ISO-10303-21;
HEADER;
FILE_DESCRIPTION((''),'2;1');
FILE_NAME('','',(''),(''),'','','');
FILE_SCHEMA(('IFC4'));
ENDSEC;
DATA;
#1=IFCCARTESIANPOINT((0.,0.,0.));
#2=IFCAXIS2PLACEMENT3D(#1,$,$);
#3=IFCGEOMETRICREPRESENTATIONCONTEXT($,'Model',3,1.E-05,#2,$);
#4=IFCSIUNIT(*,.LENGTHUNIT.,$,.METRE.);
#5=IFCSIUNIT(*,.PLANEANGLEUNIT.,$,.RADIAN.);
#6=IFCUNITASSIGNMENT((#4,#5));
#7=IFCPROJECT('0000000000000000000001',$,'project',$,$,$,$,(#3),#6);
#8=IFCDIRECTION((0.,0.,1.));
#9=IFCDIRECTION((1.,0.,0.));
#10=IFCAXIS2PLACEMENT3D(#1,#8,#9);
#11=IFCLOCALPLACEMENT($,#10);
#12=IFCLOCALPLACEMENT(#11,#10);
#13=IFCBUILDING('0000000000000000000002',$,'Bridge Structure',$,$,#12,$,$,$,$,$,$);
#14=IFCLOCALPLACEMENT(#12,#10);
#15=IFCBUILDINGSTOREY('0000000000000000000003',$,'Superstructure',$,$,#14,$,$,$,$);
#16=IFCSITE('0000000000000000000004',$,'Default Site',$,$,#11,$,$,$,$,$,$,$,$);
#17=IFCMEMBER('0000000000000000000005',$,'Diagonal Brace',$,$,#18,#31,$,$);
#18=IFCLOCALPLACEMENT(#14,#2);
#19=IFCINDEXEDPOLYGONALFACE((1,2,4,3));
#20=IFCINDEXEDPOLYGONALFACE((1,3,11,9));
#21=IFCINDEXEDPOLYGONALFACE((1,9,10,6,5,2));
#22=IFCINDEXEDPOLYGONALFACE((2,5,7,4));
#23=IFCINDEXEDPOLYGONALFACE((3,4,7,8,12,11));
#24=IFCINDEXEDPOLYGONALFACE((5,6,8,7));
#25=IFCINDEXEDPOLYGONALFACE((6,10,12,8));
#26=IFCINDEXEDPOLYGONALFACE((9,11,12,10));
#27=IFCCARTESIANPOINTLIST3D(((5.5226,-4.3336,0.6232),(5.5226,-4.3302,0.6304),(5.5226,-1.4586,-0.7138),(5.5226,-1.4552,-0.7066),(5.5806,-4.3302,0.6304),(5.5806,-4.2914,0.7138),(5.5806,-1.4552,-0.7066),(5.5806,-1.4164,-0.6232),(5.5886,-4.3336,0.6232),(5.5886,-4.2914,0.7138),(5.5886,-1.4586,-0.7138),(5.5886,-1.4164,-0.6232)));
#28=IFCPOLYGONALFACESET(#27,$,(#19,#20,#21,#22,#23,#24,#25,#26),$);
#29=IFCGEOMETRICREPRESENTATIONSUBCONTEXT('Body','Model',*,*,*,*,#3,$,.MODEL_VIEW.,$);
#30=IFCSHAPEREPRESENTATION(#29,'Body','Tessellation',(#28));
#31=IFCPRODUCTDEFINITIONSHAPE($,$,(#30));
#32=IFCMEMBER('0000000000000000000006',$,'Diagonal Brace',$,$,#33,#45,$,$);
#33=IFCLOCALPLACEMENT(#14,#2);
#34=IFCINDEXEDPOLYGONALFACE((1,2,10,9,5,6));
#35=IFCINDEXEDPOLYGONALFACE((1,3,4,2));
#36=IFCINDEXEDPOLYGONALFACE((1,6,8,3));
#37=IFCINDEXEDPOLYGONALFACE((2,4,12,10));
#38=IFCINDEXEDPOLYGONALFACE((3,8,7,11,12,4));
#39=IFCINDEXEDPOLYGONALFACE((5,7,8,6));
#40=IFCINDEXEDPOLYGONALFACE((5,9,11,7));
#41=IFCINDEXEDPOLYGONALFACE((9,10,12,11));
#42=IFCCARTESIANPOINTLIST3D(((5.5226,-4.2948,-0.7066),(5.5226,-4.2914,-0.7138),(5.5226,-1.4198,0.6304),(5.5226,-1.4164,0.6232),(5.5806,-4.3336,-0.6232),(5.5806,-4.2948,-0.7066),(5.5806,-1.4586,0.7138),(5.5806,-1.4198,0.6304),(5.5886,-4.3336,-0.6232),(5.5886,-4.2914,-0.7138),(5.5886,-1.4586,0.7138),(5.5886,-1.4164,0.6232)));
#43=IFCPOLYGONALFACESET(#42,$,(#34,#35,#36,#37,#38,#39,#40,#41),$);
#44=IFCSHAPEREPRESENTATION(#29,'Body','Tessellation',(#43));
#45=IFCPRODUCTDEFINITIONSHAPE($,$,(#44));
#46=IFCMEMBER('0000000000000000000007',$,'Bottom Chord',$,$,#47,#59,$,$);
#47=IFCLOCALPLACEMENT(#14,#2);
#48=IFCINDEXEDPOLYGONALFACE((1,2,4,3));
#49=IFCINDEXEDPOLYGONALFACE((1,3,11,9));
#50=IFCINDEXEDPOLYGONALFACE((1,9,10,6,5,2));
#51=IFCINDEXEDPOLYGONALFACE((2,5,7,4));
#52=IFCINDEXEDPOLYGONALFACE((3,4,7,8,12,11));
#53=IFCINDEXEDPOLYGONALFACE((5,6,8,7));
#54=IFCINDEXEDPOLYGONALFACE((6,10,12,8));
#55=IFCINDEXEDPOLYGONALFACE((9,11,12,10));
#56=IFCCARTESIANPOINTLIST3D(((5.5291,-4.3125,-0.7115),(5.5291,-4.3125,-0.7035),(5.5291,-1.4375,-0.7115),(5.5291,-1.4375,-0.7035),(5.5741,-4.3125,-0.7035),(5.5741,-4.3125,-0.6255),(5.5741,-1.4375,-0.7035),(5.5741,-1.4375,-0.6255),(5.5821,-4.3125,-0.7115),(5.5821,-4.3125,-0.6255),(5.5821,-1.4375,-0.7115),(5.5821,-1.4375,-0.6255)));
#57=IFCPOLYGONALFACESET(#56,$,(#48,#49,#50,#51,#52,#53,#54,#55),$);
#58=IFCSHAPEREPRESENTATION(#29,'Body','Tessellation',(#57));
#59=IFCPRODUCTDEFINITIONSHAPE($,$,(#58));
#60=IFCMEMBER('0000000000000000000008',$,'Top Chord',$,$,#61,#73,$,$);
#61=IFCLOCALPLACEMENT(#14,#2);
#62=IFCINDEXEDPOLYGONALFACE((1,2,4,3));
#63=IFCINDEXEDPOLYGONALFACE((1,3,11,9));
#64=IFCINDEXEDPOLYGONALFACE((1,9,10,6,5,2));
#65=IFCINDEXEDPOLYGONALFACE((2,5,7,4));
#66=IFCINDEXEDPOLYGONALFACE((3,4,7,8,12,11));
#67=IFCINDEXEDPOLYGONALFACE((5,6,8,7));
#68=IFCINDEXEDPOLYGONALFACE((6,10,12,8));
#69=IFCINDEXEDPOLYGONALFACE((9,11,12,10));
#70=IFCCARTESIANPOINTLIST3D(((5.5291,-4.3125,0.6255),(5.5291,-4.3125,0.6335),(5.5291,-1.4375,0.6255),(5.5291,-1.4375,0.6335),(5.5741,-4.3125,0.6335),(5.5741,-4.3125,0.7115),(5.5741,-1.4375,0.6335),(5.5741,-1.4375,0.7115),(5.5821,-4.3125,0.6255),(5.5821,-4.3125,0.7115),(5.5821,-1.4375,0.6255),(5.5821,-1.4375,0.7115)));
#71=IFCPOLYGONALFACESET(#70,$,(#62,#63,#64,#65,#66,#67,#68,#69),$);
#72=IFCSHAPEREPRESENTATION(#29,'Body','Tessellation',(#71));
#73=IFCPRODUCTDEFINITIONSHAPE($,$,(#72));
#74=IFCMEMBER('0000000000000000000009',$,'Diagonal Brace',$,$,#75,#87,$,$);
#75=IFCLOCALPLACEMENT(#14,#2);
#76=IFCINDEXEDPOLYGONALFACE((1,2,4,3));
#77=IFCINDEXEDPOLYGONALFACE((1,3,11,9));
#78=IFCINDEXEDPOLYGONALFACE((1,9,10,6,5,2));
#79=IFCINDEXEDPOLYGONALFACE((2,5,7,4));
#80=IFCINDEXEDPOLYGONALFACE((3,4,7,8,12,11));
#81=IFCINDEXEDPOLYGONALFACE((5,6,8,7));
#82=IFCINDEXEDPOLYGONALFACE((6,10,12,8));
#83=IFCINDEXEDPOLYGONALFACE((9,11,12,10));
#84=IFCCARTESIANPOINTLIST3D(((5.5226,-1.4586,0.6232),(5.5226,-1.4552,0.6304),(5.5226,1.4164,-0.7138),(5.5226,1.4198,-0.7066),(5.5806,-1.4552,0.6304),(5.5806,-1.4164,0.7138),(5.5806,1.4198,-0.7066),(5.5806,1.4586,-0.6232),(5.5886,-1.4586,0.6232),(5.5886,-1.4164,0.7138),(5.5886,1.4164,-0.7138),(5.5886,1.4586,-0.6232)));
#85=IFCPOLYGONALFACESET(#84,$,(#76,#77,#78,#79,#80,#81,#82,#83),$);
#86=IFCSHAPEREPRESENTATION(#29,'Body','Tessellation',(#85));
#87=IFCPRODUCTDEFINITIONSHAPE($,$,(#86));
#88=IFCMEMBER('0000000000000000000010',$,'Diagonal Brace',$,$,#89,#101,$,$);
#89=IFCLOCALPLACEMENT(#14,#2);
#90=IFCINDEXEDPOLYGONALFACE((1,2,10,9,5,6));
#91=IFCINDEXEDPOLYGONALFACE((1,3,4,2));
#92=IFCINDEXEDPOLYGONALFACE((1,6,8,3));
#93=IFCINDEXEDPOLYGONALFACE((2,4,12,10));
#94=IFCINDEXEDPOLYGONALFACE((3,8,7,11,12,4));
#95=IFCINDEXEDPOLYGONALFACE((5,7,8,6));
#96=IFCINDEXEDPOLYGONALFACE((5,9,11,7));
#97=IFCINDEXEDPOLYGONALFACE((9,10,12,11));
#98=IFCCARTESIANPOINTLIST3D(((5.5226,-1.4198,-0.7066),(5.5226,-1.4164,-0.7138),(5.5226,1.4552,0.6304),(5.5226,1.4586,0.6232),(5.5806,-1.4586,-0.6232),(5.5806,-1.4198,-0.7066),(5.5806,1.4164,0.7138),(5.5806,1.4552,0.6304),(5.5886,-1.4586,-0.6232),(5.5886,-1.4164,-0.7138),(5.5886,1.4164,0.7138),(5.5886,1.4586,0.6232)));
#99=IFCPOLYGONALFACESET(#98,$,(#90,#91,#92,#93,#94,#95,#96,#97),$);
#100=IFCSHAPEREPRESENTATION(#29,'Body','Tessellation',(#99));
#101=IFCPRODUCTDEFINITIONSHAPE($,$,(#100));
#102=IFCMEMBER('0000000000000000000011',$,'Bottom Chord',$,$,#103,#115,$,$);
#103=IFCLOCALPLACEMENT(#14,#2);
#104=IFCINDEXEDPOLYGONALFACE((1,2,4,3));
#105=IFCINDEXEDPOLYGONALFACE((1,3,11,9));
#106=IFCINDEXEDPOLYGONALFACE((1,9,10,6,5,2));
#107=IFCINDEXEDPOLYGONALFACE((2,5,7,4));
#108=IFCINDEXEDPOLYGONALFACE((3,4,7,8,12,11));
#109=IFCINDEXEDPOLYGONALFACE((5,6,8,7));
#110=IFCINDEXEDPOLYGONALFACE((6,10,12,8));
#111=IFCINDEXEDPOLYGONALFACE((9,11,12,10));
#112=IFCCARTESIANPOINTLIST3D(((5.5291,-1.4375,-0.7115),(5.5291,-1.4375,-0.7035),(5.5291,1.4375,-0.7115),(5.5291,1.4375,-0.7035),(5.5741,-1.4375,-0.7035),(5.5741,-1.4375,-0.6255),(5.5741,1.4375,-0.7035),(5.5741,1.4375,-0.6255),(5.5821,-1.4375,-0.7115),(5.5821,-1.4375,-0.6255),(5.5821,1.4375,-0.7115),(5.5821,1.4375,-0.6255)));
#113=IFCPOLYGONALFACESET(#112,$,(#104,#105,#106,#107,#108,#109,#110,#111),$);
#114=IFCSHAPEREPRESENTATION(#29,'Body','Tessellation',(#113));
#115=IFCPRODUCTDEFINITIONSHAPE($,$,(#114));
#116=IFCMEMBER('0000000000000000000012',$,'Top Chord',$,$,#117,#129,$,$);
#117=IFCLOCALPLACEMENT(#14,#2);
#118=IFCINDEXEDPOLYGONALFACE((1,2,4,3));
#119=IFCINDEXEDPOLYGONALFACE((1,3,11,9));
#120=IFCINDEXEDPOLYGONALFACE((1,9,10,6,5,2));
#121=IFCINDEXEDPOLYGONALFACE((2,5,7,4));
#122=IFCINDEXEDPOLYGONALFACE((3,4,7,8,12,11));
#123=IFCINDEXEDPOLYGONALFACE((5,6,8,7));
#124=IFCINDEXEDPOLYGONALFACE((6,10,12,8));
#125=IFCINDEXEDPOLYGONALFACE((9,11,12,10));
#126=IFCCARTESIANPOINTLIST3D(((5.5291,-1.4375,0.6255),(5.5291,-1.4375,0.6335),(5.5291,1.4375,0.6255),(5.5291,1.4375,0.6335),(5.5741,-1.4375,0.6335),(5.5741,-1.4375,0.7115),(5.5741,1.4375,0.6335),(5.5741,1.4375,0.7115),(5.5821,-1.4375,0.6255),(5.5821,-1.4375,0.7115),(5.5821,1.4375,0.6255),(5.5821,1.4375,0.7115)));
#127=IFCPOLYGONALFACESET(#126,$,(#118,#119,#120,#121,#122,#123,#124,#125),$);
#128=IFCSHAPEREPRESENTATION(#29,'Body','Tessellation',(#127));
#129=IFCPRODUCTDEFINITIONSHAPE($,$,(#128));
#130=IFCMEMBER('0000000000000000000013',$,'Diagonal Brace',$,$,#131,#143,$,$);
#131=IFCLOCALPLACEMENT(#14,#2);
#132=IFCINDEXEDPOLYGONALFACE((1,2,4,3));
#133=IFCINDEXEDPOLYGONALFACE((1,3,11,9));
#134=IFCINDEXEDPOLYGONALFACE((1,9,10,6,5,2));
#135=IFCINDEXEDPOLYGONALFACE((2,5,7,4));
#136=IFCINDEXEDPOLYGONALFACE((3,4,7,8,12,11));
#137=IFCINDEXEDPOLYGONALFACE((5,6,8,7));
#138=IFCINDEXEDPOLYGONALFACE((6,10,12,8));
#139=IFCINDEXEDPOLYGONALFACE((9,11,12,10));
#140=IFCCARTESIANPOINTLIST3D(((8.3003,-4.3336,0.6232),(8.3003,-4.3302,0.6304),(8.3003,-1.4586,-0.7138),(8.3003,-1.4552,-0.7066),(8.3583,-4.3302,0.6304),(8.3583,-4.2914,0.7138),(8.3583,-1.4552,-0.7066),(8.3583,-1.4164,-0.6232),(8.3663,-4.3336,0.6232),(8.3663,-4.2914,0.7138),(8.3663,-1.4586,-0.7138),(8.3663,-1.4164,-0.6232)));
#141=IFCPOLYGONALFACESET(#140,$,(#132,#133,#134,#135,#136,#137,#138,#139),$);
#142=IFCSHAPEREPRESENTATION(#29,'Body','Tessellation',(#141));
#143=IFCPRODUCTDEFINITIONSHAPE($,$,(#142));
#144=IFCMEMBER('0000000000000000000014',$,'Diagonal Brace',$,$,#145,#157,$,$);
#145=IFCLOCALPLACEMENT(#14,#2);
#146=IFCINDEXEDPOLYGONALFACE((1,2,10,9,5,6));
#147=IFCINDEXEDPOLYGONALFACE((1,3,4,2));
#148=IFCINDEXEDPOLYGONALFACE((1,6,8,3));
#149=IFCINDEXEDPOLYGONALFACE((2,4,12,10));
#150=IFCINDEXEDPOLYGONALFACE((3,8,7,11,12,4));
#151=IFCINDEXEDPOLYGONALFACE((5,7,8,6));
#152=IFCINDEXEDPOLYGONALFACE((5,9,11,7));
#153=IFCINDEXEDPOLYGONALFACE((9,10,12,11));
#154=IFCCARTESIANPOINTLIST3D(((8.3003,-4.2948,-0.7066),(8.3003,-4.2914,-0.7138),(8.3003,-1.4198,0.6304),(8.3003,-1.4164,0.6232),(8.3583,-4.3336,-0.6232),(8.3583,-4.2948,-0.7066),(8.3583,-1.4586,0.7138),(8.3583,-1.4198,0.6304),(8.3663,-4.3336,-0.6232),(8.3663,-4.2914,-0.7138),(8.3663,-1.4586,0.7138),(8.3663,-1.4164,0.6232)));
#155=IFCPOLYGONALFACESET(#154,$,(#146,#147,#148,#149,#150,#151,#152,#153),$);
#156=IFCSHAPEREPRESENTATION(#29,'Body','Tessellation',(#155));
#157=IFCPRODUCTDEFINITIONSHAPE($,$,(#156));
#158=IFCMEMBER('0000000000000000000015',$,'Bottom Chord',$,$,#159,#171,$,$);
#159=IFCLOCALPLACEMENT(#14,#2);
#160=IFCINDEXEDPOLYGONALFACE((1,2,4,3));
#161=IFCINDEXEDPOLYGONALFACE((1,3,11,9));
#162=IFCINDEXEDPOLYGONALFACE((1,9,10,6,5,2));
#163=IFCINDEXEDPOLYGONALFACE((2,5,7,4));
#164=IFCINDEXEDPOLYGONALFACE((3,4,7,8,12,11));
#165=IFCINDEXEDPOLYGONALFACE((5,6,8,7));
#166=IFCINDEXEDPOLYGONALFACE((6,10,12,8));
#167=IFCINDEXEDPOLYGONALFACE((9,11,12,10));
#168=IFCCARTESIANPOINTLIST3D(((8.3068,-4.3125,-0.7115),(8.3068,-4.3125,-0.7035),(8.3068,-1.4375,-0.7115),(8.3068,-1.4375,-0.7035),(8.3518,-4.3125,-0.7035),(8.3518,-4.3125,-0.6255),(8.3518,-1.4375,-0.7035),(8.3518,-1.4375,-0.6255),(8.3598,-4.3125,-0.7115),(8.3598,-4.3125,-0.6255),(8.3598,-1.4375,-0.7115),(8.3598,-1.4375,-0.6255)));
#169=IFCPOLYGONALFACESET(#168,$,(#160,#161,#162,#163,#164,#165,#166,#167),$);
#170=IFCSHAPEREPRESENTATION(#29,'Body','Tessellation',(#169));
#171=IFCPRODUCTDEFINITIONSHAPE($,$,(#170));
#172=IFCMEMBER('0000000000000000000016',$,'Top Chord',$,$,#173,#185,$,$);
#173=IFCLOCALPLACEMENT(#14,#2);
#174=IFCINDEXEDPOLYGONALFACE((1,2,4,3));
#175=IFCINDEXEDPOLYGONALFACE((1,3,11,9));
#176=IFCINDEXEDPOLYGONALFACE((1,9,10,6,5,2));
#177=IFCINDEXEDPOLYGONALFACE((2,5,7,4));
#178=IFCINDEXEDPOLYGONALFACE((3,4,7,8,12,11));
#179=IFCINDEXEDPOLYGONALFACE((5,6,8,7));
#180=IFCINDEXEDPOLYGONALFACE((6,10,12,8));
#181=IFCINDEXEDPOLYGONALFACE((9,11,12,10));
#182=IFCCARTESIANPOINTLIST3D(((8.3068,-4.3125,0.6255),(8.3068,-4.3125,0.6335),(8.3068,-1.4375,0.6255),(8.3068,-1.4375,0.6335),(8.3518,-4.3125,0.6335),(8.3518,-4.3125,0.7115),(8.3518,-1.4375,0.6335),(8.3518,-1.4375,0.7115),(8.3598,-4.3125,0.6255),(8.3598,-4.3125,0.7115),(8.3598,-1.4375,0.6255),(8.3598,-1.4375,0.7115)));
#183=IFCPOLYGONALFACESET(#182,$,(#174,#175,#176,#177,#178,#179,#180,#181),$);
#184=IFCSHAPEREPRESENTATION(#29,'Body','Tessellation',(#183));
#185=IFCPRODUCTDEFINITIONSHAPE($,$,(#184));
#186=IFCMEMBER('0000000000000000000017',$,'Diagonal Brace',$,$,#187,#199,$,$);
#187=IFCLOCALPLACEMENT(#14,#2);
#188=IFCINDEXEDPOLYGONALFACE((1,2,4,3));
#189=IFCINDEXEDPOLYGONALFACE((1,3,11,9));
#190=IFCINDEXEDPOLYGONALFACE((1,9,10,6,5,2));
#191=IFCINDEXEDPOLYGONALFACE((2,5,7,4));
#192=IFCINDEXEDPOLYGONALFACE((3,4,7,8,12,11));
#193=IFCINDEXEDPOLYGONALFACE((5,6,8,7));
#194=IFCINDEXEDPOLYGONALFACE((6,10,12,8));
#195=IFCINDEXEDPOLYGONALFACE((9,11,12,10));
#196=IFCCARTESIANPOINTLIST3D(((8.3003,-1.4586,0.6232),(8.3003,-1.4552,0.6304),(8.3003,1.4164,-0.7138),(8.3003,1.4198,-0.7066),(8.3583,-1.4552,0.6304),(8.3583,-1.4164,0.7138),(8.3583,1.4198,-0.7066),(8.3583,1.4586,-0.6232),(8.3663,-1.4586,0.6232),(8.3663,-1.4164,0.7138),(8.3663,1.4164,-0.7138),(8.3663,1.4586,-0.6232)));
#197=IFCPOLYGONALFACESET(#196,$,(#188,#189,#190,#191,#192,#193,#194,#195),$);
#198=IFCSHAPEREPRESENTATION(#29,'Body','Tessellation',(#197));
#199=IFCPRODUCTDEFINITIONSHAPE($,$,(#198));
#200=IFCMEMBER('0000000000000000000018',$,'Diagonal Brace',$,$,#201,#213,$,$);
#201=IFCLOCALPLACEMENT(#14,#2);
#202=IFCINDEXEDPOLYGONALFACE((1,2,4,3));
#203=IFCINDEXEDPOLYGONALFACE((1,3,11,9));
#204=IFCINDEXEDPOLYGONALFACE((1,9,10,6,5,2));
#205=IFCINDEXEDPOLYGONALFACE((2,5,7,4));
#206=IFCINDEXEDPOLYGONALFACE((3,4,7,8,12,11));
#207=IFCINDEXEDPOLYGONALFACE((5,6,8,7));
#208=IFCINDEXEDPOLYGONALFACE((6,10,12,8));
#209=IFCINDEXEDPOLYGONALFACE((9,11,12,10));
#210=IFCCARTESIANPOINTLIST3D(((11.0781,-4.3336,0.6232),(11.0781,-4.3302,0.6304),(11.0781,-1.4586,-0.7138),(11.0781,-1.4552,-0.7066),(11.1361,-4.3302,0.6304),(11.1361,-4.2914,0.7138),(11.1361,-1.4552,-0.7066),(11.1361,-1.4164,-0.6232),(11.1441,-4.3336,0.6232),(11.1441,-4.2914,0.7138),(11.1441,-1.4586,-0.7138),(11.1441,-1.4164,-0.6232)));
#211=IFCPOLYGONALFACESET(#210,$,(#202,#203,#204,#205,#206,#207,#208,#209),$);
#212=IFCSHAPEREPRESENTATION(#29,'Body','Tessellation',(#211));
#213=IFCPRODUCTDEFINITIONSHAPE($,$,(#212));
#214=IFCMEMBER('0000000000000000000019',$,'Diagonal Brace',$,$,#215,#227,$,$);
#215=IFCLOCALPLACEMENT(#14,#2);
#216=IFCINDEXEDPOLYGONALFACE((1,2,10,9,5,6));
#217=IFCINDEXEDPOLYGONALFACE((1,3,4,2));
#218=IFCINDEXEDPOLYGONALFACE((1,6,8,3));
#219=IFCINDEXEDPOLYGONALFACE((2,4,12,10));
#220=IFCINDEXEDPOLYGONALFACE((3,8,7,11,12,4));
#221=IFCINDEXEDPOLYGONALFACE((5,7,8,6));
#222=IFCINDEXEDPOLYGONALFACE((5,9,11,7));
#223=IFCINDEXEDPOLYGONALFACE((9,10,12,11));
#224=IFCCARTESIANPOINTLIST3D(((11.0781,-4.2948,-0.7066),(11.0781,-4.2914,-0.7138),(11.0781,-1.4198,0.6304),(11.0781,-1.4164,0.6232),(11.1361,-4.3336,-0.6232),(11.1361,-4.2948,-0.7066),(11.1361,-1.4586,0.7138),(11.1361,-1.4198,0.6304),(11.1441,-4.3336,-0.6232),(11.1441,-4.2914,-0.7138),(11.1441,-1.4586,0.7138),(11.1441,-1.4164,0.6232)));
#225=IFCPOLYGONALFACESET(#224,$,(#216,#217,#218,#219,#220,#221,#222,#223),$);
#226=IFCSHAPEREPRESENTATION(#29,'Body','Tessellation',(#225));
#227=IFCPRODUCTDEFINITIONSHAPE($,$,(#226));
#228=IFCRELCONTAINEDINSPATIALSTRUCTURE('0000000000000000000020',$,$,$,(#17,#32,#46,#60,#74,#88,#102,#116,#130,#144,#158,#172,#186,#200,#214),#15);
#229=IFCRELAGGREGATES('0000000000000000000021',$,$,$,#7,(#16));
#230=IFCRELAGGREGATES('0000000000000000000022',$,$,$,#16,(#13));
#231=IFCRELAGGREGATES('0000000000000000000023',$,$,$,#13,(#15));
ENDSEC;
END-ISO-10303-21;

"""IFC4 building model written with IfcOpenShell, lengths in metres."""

from ifc_helpers import new_model, si_unit, frame, origin, origin_with_axes, origin_2d_with_axis, place, context, subcontext, project, spatial, l_section, extrude, element, save


model = new_model("IFC4")

# Units and contexts
model_context = context("Model", 3, precision=1e-05, world=origin())
body_context = subcontext(model_context, "Body", "Model", "MODEL_VIEW")
ifc_project = project(units=[si_unit("LENGTHUNIT", "METRE"), si_unit("PLANEANGLEUNIT", "RADIAN")], contexts=[model_context])

# Site, building, storey
site_placement = place(None, origin_with_axes())
site = spatial("IfcSite", under=ifc_project, at=site_placement, Name="Default Site")
building_placement = place(site_placement, origin_with_axes())
building = spatial("IfcBuilding", under=site, at=building_placement, Name="Bridge Structure")
storey_placement = place(building_placement, origin_with_axes())
storey = spatial("IfcBuildingStorey", under=building, at=storey_placement, Name="Superstructure")

# Members
for number, where, z_axis, x_axis, name in (
    (1, (5.5556, -4.3125, 0.6685), (0.0, 0.906746, -0.421676), (-1.0, 0.0, 0.0), "Diagonal Brace"),
    (2, (5.5556, -4.3125, -0.6685), (0.0, 0.906746, 0.421676), (-1.0, 0.0, 0.0), "Diagonal Brace"),
):
    element("IfcMember", number, at=place(storey_placement, frame(where, z_axis=z_axis, x_axis=x_axis)), inside=storey, Name=name, context=body_context, shape_type="SweptSolid", body=[
        extrude(l_section(Depth=0.1, Width=0.066, Thickness=0.008, at=origin_2d_with_axis()), origin_with_axes(), (0.0, 0.0, 1.0), 3.1707),
    ])
for number, where, z_axis, x_axis, name in (
    (3, (5.5556, -4.3125, -0.6685), (0.0, 1.0, 0.0), (-1.0, 0.0, 0.0), "Bottom Chord"),
    (4, (5.5556, -4.3125, 0.6685), (0.0, 1.0, 0.0), (-1.0, 0.0, 0.0), "Top Chord"),
):
    element("IfcMember", number, at=place(storey_placement, frame(where, z_axis=z_axis, x_axis=x_axis)), inside=storey, Name=name, context=body_context, shape_type="SweptSolid", body=[
        extrude(l_section(Depth=0.086, Width=0.053, Thickness=0.008, at=origin_2d_with_axis()), origin_with_axes(), (0.0, 0.0, 1.0), 2.875),
    ])
for number, where, z_axis, x_axis, name in (
    (5, (5.5556, -1.4375, 0.6685), (0.0, 0.906746, -0.421676), (-1.0, 0.0, 0.0), "Diagonal Brace"),
    (6, (5.5556, -1.4375, -0.6685), (0.0, 0.906746, 0.421676), (-1.0, 0.0, 0.0), "Diagonal Brace"),
):
    element("IfcMember", number, at=place(storey_placement, frame(where, z_axis=z_axis, x_axis=x_axis)), inside=storey, Name=name, context=body_context, shape_type="SweptSolid", body=[
        extrude(l_section(Depth=0.1, Width=0.066, Thickness=0.008, at=origin_2d_with_axis()), origin_with_axes(), (0.0, 0.0, 1.0), 3.1707),
    ])
for number, where, z_axis, x_axis, name in (
    (7, (5.5556, -1.4375, -0.6685), (0.0, 1.0, 0.0), (-1.0, 0.0, 0.0), "Bottom Chord"),
    (8, (5.5556, -1.4375, 0.6685), (0.0, 1.0, 0.0), (-1.0, 0.0, 0.0), "Top Chord"),
):
    element("IfcMember", number, at=place(storey_placement, frame(where, z_axis=z_axis, x_axis=x_axis)), inside=storey, Name=name, context=body_context, shape_type="SweptSolid", body=[
        extrude(l_section(Depth=0.086, Width=0.053, Thickness=0.008, at=origin_2d_with_axis()), origin_with_axes(), (0.0, 0.0, 1.0), 2.875),
    ])
for number, where, z_axis, x_axis, name in (
    (9, (8.3333, -4.3125, 0.6685), (0.0, 0.906746, -0.421676), (-1.0, 0.0, 0.0), "Diagonal Brace"),
    (10, (8.3333, -4.3125, -0.6685), (0.0, 0.906746, 0.421676), (-1.0, 0.0, 0.0), "Diagonal Brace"),
):
    element("IfcMember", number, at=place(storey_placement, frame(where, z_axis=z_axis, x_axis=x_axis)), inside=storey, Name=name, context=body_context, shape_type="SweptSolid", body=[
        extrude(l_section(Depth=0.1, Width=0.066, Thickness=0.008, at=origin_2d_with_axis()), origin_with_axes(), (0.0, 0.0, 1.0), 3.1707),
    ])
for number, where, z_axis, x_axis, name in (
    (11, (8.3333, -4.3125, -0.6685), (0.0, 1.0, 0.0), (-1.0, 0.0, 0.0), "Bottom Chord"),
    (12, (8.3333, -4.3125, 0.6685), (0.0, 1.0, 0.0), (-1.0, 0.0, 0.0), "Top Chord"),
):
    element("IfcMember", number, at=place(storey_placement, frame(where, z_axis=z_axis, x_axis=x_axis)), inside=storey, Name=name, context=body_context, shape_type="SweptSolid", body=[
        extrude(l_section(Depth=0.086, Width=0.053, Thickness=0.008, at=origin_2d_with_axis()), origin_with_axes(), (0.0, 0.0, 1.0), 2.875),
    ])
for number, where, z_axis, x_axis, name in (
    (13, (8.3333, -1.4375, 0.6685), (0.0, 0.906746, -0.421676), (-1.0, 0.0, 0.0), "Diagonal Brace"),
    (14, (11.1111, -4.3125, 0.6685), (0.0, 0.906746, -0.421676), (-1.0, 0.0, 0.0), "Diagonal Brace"),
    (15, (11.1111, -4.3125, -0.6685), (0.0, 0.906746, 0.421676), (-1.0, 0.0, 0.0), "Diagonal Brace"),
):
    element("IfcMember", number, at=place(storey_placement, frame(where, z_axis=z_axis, x_axis=x_axis)), inside=storey, Name=name, context=body_context, shape_type="SweptSolid", body=[
        extrude(l_section(Depth=0.1, Width=0.066, Thickness=0.008, at=origin_2d_with_axis()), origin_with_axes(), (0.0, 0.0, 1.0), 3.1707),
    ])

save(model, "model.ifc")
